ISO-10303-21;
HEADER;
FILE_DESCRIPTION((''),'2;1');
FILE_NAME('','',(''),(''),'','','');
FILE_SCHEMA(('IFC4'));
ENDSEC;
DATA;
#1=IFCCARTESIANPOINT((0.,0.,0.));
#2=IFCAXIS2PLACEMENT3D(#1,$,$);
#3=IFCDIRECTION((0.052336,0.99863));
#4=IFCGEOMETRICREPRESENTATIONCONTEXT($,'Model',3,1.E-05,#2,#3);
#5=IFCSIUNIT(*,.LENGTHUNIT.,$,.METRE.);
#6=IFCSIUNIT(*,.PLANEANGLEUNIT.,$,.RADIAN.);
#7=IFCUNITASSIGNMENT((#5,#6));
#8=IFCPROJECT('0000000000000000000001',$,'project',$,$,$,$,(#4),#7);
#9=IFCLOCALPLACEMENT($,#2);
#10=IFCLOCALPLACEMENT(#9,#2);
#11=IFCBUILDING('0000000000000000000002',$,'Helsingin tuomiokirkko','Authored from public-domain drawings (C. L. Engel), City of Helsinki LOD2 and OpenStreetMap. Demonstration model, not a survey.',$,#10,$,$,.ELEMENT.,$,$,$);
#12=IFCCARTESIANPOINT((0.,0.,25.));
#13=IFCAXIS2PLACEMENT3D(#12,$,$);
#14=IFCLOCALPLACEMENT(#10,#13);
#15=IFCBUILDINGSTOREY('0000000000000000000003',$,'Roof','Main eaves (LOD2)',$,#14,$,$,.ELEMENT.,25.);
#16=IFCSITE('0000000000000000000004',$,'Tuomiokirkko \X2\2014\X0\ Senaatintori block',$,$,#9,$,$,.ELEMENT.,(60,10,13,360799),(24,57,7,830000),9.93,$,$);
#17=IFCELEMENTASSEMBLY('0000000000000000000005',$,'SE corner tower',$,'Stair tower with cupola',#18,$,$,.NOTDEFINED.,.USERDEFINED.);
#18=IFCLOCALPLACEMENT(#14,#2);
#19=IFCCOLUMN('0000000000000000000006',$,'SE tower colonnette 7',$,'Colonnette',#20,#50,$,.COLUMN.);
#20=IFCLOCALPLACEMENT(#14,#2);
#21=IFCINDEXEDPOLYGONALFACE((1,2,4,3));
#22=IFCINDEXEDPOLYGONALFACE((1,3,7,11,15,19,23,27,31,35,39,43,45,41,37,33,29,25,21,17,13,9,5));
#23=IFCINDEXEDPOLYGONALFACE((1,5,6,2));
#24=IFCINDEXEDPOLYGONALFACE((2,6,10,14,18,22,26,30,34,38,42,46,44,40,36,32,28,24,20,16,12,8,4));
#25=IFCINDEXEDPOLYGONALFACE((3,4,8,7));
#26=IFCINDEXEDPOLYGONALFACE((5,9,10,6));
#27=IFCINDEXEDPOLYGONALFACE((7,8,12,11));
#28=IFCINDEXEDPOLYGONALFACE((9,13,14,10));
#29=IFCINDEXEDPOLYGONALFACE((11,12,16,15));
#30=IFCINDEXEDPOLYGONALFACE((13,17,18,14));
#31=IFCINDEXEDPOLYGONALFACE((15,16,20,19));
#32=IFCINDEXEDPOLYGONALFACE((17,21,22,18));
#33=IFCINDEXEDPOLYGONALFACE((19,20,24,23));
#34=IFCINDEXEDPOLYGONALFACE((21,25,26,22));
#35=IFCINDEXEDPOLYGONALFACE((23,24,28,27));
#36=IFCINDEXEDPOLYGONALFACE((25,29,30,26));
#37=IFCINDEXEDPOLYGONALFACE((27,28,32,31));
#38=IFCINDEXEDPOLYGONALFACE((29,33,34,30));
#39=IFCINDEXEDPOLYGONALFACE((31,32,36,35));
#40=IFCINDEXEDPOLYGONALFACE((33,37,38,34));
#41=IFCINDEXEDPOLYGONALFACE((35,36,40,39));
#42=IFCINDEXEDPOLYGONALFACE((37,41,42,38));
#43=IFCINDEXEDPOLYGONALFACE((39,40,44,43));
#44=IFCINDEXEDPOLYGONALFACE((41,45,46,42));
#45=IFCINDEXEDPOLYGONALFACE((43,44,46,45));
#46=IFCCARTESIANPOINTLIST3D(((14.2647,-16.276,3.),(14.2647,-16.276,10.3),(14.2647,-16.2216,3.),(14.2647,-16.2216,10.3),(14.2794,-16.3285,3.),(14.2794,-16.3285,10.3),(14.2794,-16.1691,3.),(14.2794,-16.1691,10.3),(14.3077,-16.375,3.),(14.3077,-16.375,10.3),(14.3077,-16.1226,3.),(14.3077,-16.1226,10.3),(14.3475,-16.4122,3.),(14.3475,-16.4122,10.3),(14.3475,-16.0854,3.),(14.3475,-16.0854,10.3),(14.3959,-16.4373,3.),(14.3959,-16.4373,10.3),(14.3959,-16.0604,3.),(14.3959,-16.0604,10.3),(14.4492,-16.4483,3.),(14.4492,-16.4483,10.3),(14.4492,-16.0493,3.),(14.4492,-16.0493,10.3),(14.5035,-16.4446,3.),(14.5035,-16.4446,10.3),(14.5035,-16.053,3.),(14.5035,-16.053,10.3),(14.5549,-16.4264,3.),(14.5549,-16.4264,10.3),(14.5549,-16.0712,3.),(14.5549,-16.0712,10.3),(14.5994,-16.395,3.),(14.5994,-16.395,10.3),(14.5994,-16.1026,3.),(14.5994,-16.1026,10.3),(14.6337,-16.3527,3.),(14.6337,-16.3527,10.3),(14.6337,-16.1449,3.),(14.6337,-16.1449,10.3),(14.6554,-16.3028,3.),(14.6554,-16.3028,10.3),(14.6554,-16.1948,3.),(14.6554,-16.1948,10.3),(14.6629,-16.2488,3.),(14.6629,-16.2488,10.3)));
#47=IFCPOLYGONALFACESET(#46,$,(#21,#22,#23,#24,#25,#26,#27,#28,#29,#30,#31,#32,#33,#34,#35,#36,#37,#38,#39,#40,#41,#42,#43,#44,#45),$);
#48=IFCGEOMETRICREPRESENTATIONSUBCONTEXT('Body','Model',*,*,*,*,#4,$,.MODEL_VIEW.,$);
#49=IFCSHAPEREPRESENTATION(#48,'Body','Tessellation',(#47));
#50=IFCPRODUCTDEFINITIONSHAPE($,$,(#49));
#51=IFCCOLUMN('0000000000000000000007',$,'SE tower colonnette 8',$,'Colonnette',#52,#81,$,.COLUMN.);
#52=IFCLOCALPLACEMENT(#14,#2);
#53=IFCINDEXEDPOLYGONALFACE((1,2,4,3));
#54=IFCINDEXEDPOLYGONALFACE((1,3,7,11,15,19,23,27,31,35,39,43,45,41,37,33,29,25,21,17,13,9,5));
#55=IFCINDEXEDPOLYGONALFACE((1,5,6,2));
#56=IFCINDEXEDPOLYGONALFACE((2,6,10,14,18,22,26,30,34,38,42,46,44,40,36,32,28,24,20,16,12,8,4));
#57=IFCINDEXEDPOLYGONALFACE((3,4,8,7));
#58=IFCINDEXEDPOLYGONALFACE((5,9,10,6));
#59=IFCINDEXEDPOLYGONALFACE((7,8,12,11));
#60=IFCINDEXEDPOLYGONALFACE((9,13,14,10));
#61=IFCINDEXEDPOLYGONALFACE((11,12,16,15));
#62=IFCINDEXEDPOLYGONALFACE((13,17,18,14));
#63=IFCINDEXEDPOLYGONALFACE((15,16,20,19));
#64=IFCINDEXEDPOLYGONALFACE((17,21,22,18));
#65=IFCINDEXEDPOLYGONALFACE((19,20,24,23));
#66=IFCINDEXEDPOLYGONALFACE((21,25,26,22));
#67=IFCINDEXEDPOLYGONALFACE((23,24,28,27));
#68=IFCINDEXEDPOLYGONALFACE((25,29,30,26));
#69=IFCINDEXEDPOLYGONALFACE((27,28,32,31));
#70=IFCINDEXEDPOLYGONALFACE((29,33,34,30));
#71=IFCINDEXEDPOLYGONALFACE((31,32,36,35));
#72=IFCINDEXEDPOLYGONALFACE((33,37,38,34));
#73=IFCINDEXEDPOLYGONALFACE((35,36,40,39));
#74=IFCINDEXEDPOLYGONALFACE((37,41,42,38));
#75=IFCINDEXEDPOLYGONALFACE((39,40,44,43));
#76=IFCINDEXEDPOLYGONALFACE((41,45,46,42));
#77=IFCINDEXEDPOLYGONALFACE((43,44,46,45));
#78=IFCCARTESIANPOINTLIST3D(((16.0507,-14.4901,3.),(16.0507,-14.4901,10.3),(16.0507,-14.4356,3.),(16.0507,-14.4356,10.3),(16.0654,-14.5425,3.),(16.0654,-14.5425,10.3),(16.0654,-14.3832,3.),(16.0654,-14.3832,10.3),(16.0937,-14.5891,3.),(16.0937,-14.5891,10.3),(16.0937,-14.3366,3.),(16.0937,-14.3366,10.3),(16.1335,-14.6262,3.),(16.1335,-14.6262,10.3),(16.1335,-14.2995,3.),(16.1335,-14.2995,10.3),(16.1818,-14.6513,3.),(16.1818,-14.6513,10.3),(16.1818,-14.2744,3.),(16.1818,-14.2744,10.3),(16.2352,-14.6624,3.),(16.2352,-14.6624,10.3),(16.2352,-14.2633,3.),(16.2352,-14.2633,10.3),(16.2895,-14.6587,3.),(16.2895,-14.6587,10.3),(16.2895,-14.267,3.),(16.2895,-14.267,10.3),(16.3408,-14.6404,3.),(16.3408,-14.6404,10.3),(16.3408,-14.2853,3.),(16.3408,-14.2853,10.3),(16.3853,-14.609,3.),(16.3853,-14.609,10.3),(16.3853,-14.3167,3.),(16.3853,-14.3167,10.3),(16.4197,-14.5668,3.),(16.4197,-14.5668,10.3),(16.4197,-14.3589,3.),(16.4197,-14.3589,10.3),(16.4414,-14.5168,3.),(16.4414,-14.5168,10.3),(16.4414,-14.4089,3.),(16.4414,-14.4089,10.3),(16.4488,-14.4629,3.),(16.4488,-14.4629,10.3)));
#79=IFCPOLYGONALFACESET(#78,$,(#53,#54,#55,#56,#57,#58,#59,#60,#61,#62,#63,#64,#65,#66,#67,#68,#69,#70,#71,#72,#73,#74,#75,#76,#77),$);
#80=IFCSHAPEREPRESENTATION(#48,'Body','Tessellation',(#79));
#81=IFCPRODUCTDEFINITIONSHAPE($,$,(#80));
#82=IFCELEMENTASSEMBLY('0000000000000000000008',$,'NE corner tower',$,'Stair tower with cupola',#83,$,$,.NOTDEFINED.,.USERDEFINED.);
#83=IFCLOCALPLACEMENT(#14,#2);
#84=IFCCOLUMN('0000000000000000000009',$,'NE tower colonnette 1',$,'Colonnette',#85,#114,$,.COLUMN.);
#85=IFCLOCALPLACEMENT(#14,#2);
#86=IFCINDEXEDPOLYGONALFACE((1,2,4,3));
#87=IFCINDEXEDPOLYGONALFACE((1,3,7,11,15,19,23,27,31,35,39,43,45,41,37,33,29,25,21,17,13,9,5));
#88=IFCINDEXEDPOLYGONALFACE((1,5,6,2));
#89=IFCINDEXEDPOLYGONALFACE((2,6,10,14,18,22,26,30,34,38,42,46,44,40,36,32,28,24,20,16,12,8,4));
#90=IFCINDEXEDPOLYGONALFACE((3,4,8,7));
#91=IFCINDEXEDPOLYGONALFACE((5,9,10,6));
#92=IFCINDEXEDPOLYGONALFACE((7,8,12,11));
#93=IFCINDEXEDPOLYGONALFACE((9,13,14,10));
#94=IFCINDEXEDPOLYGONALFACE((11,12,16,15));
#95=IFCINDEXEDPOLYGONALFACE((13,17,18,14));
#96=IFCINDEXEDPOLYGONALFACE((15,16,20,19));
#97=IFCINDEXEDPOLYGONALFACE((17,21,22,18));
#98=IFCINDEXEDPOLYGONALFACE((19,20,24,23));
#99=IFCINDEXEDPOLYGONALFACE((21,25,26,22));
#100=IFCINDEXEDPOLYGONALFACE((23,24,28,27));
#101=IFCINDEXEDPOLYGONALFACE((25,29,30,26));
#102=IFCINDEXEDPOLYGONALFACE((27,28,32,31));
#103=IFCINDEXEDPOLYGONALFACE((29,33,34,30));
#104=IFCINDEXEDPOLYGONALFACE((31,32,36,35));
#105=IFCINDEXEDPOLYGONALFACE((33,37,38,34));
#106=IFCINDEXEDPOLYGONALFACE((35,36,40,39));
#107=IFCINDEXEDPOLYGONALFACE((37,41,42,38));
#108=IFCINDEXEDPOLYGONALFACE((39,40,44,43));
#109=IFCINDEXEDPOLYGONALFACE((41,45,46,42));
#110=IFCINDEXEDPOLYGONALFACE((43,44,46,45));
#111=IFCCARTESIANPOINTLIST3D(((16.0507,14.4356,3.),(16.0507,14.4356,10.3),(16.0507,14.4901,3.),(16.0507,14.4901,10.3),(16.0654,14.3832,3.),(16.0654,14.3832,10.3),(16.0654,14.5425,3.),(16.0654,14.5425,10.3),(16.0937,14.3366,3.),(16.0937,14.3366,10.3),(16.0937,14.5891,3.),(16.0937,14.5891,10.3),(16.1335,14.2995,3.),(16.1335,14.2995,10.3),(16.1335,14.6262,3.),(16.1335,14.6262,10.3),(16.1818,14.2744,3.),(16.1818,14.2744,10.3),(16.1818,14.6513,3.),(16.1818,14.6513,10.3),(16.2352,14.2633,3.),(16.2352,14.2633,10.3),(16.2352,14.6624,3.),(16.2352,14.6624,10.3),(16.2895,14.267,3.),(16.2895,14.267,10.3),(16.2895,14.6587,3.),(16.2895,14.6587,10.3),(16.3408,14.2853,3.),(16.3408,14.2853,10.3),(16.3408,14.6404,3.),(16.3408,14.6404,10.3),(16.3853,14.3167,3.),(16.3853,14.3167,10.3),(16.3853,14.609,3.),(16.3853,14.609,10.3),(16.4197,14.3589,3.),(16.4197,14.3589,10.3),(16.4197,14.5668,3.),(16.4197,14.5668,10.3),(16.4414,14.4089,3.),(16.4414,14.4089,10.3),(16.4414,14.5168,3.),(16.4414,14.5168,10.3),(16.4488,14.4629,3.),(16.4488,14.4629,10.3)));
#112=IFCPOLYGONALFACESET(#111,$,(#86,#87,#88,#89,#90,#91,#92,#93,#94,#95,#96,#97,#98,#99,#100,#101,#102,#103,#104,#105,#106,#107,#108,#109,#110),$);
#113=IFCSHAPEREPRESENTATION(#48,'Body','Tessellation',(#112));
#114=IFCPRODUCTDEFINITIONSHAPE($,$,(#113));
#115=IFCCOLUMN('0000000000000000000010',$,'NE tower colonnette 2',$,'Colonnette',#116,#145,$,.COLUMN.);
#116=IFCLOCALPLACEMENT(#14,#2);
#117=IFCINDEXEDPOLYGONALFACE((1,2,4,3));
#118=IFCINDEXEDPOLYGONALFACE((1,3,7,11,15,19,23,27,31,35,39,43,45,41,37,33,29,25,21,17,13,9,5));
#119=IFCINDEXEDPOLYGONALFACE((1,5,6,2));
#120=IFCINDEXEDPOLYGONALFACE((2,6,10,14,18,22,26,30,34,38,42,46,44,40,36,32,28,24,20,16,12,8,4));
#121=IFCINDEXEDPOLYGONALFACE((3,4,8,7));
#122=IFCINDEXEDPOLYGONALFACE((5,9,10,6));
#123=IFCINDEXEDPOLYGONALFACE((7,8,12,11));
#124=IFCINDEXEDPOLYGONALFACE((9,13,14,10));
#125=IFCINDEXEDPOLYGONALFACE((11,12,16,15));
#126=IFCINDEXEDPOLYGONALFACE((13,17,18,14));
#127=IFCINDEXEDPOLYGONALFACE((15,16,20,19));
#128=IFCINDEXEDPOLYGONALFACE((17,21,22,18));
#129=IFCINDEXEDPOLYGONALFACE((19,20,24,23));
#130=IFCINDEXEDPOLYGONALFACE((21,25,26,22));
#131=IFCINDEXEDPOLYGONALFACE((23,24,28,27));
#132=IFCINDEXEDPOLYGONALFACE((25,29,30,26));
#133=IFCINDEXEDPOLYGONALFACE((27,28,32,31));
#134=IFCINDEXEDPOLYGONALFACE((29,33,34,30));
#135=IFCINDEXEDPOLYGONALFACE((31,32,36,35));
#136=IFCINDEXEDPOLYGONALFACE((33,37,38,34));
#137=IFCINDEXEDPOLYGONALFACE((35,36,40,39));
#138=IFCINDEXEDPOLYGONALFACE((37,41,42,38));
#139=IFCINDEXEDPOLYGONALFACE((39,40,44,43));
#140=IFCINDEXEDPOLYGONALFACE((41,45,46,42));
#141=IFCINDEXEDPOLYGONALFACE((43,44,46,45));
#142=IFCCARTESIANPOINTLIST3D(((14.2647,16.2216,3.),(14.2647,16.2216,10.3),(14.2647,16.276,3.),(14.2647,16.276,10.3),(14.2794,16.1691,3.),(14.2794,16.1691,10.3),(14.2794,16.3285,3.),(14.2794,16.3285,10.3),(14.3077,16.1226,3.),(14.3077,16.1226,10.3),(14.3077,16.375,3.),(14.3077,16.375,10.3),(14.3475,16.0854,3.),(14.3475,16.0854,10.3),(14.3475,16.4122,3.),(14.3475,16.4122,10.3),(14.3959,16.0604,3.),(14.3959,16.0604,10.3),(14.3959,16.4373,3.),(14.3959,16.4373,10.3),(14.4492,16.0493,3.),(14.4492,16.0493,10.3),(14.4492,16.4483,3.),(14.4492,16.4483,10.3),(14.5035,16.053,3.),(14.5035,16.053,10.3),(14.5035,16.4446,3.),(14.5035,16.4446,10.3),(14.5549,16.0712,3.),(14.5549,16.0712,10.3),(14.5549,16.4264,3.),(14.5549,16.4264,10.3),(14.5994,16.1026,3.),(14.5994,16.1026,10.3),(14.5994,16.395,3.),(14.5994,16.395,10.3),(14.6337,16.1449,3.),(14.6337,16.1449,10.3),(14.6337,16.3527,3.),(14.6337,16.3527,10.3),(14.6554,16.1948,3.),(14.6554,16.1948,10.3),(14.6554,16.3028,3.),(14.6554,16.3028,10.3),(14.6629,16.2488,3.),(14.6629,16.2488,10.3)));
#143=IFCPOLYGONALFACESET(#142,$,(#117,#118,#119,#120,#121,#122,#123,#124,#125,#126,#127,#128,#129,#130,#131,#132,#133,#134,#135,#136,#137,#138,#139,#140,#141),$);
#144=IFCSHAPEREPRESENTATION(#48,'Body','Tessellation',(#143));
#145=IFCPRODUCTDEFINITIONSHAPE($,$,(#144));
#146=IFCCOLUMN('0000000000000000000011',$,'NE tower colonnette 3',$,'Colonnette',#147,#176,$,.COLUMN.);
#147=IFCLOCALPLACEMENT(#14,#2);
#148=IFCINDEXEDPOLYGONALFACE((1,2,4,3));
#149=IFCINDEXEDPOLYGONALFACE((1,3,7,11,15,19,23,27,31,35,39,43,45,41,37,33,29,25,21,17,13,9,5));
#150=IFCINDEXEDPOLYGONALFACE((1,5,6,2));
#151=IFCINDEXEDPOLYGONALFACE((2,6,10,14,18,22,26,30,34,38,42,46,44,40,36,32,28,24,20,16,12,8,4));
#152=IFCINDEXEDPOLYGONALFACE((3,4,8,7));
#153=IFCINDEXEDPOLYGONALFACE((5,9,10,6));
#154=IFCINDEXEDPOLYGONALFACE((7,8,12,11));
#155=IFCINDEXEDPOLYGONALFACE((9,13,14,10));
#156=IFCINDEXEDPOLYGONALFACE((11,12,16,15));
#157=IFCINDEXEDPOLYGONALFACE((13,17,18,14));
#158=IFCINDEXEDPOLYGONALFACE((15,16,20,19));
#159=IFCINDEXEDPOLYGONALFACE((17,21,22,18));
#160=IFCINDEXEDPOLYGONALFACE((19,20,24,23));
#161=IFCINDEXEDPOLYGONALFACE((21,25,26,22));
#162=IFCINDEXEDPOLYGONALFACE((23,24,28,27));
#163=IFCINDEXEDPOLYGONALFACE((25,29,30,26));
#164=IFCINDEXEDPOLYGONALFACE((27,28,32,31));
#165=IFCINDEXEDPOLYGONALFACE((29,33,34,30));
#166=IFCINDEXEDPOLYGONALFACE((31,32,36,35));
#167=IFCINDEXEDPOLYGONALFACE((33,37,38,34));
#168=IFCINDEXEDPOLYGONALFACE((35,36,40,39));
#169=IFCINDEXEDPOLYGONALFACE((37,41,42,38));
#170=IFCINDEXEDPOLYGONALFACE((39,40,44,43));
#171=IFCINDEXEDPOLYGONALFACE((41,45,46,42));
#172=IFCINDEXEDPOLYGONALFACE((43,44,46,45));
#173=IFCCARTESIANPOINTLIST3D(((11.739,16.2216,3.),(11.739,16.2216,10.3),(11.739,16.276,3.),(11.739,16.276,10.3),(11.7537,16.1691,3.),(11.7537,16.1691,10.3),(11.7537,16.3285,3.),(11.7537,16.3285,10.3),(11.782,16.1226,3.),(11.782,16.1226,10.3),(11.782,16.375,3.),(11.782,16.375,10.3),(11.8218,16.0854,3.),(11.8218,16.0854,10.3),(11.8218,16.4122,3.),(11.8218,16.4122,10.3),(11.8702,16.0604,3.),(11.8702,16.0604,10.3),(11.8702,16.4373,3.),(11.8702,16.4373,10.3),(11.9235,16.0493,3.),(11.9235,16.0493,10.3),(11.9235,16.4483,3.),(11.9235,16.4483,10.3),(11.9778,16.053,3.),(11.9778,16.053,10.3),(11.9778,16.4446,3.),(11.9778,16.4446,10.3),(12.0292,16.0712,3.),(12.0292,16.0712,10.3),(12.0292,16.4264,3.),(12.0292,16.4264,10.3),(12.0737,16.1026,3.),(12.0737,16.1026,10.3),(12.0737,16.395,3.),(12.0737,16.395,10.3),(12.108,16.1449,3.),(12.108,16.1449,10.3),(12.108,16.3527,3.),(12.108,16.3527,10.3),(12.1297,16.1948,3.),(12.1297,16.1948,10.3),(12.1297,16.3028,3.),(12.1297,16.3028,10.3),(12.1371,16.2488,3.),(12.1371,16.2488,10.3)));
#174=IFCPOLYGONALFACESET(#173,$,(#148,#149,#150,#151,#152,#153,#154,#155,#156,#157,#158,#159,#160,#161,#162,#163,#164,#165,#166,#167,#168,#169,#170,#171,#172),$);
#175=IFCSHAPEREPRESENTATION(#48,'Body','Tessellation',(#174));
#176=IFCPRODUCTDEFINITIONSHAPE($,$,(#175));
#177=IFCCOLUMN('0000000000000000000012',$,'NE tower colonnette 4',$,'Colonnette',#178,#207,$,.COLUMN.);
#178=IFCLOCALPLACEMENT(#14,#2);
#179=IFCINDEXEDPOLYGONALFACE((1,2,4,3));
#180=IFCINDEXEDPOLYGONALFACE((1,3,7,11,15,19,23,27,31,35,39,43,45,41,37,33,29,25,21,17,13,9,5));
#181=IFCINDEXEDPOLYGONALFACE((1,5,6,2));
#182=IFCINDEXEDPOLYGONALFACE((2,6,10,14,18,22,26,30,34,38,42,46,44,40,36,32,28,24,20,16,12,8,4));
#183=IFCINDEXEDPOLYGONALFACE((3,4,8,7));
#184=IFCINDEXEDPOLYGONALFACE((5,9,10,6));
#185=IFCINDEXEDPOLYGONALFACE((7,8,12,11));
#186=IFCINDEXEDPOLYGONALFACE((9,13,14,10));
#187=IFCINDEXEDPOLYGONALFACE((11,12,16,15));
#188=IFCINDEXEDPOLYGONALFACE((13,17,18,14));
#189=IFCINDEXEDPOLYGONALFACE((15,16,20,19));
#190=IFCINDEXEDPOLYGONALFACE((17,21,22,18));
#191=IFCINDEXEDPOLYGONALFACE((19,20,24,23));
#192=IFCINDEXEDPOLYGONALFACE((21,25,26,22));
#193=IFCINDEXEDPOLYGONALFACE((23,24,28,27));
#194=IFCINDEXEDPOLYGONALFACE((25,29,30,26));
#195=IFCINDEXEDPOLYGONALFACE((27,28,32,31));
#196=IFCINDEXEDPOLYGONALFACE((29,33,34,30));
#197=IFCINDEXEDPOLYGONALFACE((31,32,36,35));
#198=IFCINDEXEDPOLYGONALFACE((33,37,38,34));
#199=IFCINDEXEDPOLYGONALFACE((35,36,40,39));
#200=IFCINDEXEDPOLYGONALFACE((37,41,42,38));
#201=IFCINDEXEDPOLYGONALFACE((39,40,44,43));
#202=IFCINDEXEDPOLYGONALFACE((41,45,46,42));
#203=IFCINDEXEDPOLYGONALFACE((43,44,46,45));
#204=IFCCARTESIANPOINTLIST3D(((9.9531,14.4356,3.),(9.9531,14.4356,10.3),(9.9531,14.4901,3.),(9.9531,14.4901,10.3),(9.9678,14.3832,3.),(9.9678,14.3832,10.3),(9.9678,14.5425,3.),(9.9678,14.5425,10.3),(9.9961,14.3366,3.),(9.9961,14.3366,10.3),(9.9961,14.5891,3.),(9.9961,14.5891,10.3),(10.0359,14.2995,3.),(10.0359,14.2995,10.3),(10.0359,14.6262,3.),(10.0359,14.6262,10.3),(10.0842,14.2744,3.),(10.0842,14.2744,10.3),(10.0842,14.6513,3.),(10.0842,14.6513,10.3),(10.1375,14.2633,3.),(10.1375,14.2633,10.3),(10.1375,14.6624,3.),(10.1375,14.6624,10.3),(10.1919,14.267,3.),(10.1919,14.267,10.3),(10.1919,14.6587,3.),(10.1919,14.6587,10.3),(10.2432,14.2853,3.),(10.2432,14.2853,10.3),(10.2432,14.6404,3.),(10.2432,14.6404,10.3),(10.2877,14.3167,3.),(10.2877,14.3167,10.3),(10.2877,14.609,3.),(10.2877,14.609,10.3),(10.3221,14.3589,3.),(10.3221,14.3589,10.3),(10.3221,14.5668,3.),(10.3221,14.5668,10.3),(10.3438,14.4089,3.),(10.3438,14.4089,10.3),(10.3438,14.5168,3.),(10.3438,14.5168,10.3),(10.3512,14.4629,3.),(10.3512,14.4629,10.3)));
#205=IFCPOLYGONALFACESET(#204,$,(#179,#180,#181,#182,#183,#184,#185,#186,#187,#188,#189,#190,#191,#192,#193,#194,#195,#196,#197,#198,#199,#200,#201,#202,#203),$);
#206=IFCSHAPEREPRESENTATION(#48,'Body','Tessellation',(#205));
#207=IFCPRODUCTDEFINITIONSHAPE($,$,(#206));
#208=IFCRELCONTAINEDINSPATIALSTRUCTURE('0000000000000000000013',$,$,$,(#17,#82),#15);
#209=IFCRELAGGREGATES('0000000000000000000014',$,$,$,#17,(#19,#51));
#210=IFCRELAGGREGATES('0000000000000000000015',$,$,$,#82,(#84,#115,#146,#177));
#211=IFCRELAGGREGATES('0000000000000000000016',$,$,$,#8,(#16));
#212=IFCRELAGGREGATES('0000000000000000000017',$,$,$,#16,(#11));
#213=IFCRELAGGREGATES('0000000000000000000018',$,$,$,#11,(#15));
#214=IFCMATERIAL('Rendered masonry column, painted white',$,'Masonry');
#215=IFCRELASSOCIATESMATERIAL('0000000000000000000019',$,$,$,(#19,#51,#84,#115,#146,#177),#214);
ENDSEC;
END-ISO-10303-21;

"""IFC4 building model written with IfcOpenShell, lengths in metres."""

from ifc_helpers import new_model, si_unit, direction, frame, origin, origin_2d_with_axis, place, context, subcontext, project, spatial, circle, extrude, material, element, aggregate, save


model = new_model("IFC4")

# Units and contexts
model_context = context("Model", 3, precision=1e-05, world=origin(), true_north=direction((0.052336, 0.99863)))
body_context = subcontext(model_context, "Body", "Model", "MODEL_VIEW")
ifc_project = project(units=[si_unit("LENGTHUNIT", "METRE"), si_unit("PLANEANGLEUNIT", "RADIAN")], contexts=[model_context])

# Site, building, storey
site_placement = place(None, origin())
site = spatial("IfcSite", under=ifc_project, at=site_placement, Name="Tuomiokirkko — Senaatintori block", CompositionType="ELEMENT", RefLatitude=(60, 10, 13, 360799), RefLongitude=(24, 57, 7, 830000), RefElevation=9.93)
building_placement = place(site_placement, origin())
building = spatial("IfcBuilding", under=site, at=building_placement, Name="Helsingin tuomiokirkko", Description="Authored from public-domain drawings (C. L. Engel), City of Helsinki LOD2 and OpenStreetMap. Demonstration model, not a survey.", CompositionType="ELEMENT")
storey_placement = place(building_placement, frame((0.0, 0.0, 25.0)))
storey = spatial("IfcBuildingStorey", under=building, at=storey_placement, Name="Roof", Description="Main eaves (LOD2)", CompositionType="ELEMENT", Elevation=25.0)

# Element assemblies, columns
assembly_1_placement = place(building_placement, origin())
assembly_1 = element("IfcElementAssembly", 1, at=assembly_1_placement, inside=storey, Name="SE corner tower", ObjectType="Stair tower with cupola", AssemblyPlace="NOTDEFINED", PredefinedType="USERDEFINED")
ifc_material_1 = material(Name="Rendered masonry column, painted white", Category="Masonry")
column_1_placement = place(building_placement, origin())
column_1 = element("IfcColumn", 2, at=column_1_placement, material=ifc_material_1, Name="SE tower colonnette 7", ObjectType="Colonnette", PredefinedType="COLUMN", context=body_context, shape_type="SweptSolid", body=[
    extrude(circle(Radius=0.2, at=origin_2d_with_axis()), frame((14.4629, -16.2488, 28.0)), (0.0, 0.0, 1.0), 7.3),
])
column_2_placement = place(building_placement, origin())
column_2 = element("IfcColumn", 3, at=column_2_placement, material=ifc_material_1, Name="SE tower colonnette 8", ObjectType="Colonnette", PredefinedType="COLUMN", context=body_context, shape_type="SweptSolid", body=[
    extrude(circle(Radius=0.2, at=origin_2d_with_axis()), frame((16.2488, -14.4629, 28.0)), (0.0, 0.0, 1.0), 7.3),
])
assembly_2_placement = place(building_placement, origin())
assembly_2 = element("IfcElementAssembly", 4, at=assembly_2_placement, inside=storey, Name="NE corner tower", ObjectType="Stair tower with cupola", AssemblyPlace="NOTDEFINED", PredefinedType="USERDEFINED")
column_3_placement = place(building_placement, origin())
column_3 = element("IfcColumn", 5, at=column_3_placement, material=ifc_material_1, Name="NE tower colonnette 1", ObjectType="Colonnette", PredefinedType="COLUMN", context=body_context, shape_type="SweptSolid", body=[
    extrude(circle(Radius=0.2, at=origin_2d_with_axis()), frame((16.2488, 14.4629, 28.0)), (0.0, 0.0, 1.0), 7.3),
])
column_4_placement = place(building_placement, origin())
column_4 = element("IfcColumn", 6, at=column_4_placement, material=ifc_material_1, Name="NE tower colonnette 2", ObjectType="Colonnette", PredefinedType="COLUMN", context=body_context, shape_type="SweptSolid", body=[
    extrude(circle(Radius=0.2, at=origin_2d_with_axis()), frame((14.4629, 16.2488, 28.0)), (0.0, 0.0, 1.0), 7.3),
])
column_5_placement = place(building_placement, origin())
column_5 = element("IfcColumn", 7, at=column_5_placement, material=ifc_material_1, Name="NE tower colonnette 3", ObjectType="Colonnette", PredefinedType="COLUMN", context=body_context, shape_type="SweptSolid", body=[
    extrude(circle(Radius=0.2, at=origin_2d_with_axis()), frame((11.9371, 16.2488, 28.0)), (0.0, 0.0, 1.0), 7.3),
])
column_6_placement = place(building_placement, origin())
column_6 = element("IfcColumn", 8, at=column_6_placement, material=ifc_material_1, Name="NE tower colonnette 4", ObjectType="Colonnette", PredefinedType="COLUMN", context=body_context, shape_type="SweptSolid", body=[
    extrude(circle(Radius=0.2, at=origin_2d_with_axis()), frame((10.1512, 14.4629, 28.0)), (0.0, 0.0, 1.0), 7.3),
])

aggregate(assembly_1, [column_1, column_2])
aggregate(assembly_2, [column_3, column_4, column_5, column_6])

save(model, "model.ifc")
